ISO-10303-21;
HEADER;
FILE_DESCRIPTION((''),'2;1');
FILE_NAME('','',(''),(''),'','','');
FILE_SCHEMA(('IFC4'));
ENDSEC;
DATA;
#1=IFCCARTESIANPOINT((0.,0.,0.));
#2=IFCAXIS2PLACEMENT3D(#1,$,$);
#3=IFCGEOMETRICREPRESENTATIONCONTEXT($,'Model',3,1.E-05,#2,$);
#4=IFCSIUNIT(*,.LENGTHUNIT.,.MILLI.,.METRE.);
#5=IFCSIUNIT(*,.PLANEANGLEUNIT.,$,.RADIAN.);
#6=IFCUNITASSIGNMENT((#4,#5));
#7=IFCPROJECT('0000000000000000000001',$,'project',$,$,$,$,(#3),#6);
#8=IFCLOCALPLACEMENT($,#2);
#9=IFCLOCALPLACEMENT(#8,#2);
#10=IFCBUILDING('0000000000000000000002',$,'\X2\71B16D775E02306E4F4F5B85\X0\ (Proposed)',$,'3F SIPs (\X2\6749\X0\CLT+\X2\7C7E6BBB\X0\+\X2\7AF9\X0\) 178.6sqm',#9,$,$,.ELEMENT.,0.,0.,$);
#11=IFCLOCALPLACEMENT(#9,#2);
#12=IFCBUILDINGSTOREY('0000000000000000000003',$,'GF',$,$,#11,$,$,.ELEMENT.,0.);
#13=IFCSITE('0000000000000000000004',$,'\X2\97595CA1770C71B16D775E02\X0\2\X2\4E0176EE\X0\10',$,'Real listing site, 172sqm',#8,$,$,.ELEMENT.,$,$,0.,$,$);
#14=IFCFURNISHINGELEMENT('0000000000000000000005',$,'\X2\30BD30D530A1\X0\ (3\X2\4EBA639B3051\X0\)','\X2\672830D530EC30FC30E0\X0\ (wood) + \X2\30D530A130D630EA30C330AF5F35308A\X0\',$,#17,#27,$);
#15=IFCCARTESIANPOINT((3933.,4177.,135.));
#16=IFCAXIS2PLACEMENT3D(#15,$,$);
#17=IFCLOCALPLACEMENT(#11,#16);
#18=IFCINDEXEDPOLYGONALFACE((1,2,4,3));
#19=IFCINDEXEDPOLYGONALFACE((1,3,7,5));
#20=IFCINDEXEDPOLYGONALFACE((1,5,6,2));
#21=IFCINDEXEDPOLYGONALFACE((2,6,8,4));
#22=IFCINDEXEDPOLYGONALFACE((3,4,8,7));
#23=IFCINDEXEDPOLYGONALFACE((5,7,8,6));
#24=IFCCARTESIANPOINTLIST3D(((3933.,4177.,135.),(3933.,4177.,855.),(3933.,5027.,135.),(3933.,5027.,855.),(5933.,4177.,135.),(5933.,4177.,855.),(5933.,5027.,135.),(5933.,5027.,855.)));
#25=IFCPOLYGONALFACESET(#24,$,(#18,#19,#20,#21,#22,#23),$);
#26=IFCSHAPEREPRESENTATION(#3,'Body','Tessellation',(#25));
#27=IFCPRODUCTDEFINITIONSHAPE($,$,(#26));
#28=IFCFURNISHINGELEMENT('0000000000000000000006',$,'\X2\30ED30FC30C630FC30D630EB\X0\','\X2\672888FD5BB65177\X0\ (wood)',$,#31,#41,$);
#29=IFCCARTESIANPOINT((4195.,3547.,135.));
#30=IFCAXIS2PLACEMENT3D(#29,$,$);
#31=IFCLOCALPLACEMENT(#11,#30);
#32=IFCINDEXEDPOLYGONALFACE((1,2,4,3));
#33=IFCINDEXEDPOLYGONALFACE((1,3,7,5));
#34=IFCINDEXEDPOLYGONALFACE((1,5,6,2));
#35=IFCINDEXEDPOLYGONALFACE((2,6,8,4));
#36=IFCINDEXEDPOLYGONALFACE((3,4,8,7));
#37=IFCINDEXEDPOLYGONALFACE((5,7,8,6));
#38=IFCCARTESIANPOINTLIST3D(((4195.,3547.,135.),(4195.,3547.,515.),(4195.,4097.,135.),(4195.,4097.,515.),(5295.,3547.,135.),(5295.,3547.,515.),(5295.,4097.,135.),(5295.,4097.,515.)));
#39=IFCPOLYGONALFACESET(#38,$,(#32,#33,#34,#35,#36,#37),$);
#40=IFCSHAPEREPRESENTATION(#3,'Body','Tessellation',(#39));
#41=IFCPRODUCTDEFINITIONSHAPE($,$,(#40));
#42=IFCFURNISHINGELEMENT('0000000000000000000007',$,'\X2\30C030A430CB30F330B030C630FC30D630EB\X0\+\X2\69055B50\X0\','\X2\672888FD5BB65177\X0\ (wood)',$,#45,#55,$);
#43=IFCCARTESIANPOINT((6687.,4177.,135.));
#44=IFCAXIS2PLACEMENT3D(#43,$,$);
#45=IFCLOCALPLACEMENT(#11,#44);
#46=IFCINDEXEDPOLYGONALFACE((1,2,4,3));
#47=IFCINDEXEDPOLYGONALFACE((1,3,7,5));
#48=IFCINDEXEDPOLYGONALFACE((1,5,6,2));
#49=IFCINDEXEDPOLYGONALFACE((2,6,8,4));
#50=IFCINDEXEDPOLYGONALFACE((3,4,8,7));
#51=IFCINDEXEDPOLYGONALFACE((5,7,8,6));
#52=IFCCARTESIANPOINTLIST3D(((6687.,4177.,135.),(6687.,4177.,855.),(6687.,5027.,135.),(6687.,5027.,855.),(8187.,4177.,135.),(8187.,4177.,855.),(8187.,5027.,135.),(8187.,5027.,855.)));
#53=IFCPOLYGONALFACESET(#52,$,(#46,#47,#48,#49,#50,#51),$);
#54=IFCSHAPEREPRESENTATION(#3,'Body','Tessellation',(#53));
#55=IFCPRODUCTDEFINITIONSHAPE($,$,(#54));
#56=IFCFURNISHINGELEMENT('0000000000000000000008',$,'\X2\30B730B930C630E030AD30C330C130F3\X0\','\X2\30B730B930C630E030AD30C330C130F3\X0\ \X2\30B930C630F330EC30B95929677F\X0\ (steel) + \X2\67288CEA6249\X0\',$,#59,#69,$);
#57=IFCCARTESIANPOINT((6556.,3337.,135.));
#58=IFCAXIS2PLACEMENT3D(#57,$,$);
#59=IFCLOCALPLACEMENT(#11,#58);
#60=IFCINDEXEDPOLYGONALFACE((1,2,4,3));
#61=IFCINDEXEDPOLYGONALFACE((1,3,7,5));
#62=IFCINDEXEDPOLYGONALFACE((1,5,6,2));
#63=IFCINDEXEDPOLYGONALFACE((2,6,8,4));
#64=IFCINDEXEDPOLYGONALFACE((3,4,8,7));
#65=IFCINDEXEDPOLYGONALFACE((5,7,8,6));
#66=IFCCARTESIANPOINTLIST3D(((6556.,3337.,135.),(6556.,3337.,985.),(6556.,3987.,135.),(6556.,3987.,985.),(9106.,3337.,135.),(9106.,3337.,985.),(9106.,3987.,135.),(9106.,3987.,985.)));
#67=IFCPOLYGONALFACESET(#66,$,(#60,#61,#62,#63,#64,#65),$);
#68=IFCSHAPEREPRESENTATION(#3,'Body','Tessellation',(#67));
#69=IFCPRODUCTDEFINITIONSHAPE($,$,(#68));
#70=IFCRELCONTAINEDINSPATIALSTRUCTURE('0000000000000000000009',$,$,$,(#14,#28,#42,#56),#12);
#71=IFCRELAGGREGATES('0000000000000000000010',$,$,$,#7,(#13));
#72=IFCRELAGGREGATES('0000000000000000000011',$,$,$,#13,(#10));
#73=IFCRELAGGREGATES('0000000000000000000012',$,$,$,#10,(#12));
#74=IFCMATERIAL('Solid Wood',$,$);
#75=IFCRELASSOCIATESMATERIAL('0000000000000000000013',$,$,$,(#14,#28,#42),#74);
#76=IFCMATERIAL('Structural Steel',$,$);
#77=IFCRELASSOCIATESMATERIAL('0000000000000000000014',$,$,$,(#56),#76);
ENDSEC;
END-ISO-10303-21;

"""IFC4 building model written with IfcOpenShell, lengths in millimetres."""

from ifc_helpers import new_model, si_unit, frame, frame_2d, origin, place, context, project, spatial, rectangle, extrude, material, element, save


model = new_model("IFC4")

# Units and contexts
model_context = context("Model", 3, precision=1e-05, world=origin())
ifc_project = project(units=[si_unit("LENGTHUNIT", "METRE", prefix="MILLI"), si_unit("PLANEANGLEUNIT", "RADIAN")], contexts=[model_context])

# Site, building, storey
site_placement = place(None, origin())
site = spatial("IfcSite", under=ifc_project, at=site_placement, Name="静岡県熱海市2丁目10", ObjectType="Real listing site, 172sqm", CompositionType="ELEMENT", RefElevation=0.0)
building_placement = place(site_placement, origin())
building = spatial("IfcBuilding", under=site, at=building_placement, Name="熱海市の住宅 (Proposed)", ObjectType="3F SIPs (杉CLT+籾殻+竹) 178.6sqm", CompositionType="ELEMENT", ElevationOfRefHeight=0.0, ElevationOfTerrain=0.0)
storey_placement = place(building_placement, origin())
storey = spatial("IfcBuildingStorey", under=building, at=storey_placement, Name="GF", CompositionType="ELEMENT", Elevation=0.0)

# Shared definitions
ifc_material_1 = material(Name="Solid Wood")

# Furnishing elements
furnishing_1_placement = place(storey_placement, frame((3933.0, 4177.0, 135.0)))
element("IfcFurnishingElement", 1, at=furnishing_1_placement, inside=storey, material=ifc_material_1, Name="ソファ (3人掛け)", Description="木フレーム (wood) + ファブリック張り", context=model_context, shape_type="SweptSolid", body=[
    extrude(rectangle(XDim=2000.0, YDim=850.0, at=frame_2d((1000.0, 425.0))), frame((3933.0, 4177.0, 135.0)), (0.0, 0.0, 1.0), 720.0),
])
furnishing_2_placement = place(storey_placement, frame((4195.0, 3547.0, 135.0)))
element("IfcFurnishingElement", 2, at=furnishing_2_placement, inside=storey, material=ifc_material_1, Name="ローテーブル", Description="木製家具 (wood)", context=model_context, shape_type="SweptSolid", body=[
    extrude(rectangle(XDim=1100.0, YDim=550.0, at=frame_2d((550.0, 275.0))), frame((4195.0, 3547.0, 135.0)), (0.0, 0.0, 1.0), 380.0),
])
furnishing_3_placement = place(storey_placement, frame((6687.0, 4177.0, 135.0)))
element("IfcFurnishingElement", 3, at=furnishing_3_placement, inside=storey, material=ifc_material_1, Name="ダイニングテーブル+椅子", Description="木製家具 (wood)", context=model_context, shape_type="SweptSolid", body=[
    extrude(rectangle(XDim=1500.0, YDim=850.0, at=frame_2d((750.0, 425.0))), frame((6687.0, 4177.0, 135.0)), (0.0, 0.0, 1.0), 720.0),
])
ifc_material_2 = material(Name="Structural Steel")
furnishing_4_placement = place(storey_placement, frame((6556.0, 3337.0, 135.0)))
element("IfcFurnishingElement", 4, at=furnishing_4_placement, inside=storey, material=ifc_material_2, Name="システムキッチン", Description="システムキッチン ステンレス天板 (steel) + 木質扉", context=model_context, shape_type="SweptSolid", body=[
    extrude(rectangle(XDim=2550.0, YDim=650.0, at=frame_2d((1275.0, 325.0))), frame((6556.0, 3337.0, 135.0)), (0.0, 0.0, 1.0), 850.0),
])

save(model, "model.ifc")
